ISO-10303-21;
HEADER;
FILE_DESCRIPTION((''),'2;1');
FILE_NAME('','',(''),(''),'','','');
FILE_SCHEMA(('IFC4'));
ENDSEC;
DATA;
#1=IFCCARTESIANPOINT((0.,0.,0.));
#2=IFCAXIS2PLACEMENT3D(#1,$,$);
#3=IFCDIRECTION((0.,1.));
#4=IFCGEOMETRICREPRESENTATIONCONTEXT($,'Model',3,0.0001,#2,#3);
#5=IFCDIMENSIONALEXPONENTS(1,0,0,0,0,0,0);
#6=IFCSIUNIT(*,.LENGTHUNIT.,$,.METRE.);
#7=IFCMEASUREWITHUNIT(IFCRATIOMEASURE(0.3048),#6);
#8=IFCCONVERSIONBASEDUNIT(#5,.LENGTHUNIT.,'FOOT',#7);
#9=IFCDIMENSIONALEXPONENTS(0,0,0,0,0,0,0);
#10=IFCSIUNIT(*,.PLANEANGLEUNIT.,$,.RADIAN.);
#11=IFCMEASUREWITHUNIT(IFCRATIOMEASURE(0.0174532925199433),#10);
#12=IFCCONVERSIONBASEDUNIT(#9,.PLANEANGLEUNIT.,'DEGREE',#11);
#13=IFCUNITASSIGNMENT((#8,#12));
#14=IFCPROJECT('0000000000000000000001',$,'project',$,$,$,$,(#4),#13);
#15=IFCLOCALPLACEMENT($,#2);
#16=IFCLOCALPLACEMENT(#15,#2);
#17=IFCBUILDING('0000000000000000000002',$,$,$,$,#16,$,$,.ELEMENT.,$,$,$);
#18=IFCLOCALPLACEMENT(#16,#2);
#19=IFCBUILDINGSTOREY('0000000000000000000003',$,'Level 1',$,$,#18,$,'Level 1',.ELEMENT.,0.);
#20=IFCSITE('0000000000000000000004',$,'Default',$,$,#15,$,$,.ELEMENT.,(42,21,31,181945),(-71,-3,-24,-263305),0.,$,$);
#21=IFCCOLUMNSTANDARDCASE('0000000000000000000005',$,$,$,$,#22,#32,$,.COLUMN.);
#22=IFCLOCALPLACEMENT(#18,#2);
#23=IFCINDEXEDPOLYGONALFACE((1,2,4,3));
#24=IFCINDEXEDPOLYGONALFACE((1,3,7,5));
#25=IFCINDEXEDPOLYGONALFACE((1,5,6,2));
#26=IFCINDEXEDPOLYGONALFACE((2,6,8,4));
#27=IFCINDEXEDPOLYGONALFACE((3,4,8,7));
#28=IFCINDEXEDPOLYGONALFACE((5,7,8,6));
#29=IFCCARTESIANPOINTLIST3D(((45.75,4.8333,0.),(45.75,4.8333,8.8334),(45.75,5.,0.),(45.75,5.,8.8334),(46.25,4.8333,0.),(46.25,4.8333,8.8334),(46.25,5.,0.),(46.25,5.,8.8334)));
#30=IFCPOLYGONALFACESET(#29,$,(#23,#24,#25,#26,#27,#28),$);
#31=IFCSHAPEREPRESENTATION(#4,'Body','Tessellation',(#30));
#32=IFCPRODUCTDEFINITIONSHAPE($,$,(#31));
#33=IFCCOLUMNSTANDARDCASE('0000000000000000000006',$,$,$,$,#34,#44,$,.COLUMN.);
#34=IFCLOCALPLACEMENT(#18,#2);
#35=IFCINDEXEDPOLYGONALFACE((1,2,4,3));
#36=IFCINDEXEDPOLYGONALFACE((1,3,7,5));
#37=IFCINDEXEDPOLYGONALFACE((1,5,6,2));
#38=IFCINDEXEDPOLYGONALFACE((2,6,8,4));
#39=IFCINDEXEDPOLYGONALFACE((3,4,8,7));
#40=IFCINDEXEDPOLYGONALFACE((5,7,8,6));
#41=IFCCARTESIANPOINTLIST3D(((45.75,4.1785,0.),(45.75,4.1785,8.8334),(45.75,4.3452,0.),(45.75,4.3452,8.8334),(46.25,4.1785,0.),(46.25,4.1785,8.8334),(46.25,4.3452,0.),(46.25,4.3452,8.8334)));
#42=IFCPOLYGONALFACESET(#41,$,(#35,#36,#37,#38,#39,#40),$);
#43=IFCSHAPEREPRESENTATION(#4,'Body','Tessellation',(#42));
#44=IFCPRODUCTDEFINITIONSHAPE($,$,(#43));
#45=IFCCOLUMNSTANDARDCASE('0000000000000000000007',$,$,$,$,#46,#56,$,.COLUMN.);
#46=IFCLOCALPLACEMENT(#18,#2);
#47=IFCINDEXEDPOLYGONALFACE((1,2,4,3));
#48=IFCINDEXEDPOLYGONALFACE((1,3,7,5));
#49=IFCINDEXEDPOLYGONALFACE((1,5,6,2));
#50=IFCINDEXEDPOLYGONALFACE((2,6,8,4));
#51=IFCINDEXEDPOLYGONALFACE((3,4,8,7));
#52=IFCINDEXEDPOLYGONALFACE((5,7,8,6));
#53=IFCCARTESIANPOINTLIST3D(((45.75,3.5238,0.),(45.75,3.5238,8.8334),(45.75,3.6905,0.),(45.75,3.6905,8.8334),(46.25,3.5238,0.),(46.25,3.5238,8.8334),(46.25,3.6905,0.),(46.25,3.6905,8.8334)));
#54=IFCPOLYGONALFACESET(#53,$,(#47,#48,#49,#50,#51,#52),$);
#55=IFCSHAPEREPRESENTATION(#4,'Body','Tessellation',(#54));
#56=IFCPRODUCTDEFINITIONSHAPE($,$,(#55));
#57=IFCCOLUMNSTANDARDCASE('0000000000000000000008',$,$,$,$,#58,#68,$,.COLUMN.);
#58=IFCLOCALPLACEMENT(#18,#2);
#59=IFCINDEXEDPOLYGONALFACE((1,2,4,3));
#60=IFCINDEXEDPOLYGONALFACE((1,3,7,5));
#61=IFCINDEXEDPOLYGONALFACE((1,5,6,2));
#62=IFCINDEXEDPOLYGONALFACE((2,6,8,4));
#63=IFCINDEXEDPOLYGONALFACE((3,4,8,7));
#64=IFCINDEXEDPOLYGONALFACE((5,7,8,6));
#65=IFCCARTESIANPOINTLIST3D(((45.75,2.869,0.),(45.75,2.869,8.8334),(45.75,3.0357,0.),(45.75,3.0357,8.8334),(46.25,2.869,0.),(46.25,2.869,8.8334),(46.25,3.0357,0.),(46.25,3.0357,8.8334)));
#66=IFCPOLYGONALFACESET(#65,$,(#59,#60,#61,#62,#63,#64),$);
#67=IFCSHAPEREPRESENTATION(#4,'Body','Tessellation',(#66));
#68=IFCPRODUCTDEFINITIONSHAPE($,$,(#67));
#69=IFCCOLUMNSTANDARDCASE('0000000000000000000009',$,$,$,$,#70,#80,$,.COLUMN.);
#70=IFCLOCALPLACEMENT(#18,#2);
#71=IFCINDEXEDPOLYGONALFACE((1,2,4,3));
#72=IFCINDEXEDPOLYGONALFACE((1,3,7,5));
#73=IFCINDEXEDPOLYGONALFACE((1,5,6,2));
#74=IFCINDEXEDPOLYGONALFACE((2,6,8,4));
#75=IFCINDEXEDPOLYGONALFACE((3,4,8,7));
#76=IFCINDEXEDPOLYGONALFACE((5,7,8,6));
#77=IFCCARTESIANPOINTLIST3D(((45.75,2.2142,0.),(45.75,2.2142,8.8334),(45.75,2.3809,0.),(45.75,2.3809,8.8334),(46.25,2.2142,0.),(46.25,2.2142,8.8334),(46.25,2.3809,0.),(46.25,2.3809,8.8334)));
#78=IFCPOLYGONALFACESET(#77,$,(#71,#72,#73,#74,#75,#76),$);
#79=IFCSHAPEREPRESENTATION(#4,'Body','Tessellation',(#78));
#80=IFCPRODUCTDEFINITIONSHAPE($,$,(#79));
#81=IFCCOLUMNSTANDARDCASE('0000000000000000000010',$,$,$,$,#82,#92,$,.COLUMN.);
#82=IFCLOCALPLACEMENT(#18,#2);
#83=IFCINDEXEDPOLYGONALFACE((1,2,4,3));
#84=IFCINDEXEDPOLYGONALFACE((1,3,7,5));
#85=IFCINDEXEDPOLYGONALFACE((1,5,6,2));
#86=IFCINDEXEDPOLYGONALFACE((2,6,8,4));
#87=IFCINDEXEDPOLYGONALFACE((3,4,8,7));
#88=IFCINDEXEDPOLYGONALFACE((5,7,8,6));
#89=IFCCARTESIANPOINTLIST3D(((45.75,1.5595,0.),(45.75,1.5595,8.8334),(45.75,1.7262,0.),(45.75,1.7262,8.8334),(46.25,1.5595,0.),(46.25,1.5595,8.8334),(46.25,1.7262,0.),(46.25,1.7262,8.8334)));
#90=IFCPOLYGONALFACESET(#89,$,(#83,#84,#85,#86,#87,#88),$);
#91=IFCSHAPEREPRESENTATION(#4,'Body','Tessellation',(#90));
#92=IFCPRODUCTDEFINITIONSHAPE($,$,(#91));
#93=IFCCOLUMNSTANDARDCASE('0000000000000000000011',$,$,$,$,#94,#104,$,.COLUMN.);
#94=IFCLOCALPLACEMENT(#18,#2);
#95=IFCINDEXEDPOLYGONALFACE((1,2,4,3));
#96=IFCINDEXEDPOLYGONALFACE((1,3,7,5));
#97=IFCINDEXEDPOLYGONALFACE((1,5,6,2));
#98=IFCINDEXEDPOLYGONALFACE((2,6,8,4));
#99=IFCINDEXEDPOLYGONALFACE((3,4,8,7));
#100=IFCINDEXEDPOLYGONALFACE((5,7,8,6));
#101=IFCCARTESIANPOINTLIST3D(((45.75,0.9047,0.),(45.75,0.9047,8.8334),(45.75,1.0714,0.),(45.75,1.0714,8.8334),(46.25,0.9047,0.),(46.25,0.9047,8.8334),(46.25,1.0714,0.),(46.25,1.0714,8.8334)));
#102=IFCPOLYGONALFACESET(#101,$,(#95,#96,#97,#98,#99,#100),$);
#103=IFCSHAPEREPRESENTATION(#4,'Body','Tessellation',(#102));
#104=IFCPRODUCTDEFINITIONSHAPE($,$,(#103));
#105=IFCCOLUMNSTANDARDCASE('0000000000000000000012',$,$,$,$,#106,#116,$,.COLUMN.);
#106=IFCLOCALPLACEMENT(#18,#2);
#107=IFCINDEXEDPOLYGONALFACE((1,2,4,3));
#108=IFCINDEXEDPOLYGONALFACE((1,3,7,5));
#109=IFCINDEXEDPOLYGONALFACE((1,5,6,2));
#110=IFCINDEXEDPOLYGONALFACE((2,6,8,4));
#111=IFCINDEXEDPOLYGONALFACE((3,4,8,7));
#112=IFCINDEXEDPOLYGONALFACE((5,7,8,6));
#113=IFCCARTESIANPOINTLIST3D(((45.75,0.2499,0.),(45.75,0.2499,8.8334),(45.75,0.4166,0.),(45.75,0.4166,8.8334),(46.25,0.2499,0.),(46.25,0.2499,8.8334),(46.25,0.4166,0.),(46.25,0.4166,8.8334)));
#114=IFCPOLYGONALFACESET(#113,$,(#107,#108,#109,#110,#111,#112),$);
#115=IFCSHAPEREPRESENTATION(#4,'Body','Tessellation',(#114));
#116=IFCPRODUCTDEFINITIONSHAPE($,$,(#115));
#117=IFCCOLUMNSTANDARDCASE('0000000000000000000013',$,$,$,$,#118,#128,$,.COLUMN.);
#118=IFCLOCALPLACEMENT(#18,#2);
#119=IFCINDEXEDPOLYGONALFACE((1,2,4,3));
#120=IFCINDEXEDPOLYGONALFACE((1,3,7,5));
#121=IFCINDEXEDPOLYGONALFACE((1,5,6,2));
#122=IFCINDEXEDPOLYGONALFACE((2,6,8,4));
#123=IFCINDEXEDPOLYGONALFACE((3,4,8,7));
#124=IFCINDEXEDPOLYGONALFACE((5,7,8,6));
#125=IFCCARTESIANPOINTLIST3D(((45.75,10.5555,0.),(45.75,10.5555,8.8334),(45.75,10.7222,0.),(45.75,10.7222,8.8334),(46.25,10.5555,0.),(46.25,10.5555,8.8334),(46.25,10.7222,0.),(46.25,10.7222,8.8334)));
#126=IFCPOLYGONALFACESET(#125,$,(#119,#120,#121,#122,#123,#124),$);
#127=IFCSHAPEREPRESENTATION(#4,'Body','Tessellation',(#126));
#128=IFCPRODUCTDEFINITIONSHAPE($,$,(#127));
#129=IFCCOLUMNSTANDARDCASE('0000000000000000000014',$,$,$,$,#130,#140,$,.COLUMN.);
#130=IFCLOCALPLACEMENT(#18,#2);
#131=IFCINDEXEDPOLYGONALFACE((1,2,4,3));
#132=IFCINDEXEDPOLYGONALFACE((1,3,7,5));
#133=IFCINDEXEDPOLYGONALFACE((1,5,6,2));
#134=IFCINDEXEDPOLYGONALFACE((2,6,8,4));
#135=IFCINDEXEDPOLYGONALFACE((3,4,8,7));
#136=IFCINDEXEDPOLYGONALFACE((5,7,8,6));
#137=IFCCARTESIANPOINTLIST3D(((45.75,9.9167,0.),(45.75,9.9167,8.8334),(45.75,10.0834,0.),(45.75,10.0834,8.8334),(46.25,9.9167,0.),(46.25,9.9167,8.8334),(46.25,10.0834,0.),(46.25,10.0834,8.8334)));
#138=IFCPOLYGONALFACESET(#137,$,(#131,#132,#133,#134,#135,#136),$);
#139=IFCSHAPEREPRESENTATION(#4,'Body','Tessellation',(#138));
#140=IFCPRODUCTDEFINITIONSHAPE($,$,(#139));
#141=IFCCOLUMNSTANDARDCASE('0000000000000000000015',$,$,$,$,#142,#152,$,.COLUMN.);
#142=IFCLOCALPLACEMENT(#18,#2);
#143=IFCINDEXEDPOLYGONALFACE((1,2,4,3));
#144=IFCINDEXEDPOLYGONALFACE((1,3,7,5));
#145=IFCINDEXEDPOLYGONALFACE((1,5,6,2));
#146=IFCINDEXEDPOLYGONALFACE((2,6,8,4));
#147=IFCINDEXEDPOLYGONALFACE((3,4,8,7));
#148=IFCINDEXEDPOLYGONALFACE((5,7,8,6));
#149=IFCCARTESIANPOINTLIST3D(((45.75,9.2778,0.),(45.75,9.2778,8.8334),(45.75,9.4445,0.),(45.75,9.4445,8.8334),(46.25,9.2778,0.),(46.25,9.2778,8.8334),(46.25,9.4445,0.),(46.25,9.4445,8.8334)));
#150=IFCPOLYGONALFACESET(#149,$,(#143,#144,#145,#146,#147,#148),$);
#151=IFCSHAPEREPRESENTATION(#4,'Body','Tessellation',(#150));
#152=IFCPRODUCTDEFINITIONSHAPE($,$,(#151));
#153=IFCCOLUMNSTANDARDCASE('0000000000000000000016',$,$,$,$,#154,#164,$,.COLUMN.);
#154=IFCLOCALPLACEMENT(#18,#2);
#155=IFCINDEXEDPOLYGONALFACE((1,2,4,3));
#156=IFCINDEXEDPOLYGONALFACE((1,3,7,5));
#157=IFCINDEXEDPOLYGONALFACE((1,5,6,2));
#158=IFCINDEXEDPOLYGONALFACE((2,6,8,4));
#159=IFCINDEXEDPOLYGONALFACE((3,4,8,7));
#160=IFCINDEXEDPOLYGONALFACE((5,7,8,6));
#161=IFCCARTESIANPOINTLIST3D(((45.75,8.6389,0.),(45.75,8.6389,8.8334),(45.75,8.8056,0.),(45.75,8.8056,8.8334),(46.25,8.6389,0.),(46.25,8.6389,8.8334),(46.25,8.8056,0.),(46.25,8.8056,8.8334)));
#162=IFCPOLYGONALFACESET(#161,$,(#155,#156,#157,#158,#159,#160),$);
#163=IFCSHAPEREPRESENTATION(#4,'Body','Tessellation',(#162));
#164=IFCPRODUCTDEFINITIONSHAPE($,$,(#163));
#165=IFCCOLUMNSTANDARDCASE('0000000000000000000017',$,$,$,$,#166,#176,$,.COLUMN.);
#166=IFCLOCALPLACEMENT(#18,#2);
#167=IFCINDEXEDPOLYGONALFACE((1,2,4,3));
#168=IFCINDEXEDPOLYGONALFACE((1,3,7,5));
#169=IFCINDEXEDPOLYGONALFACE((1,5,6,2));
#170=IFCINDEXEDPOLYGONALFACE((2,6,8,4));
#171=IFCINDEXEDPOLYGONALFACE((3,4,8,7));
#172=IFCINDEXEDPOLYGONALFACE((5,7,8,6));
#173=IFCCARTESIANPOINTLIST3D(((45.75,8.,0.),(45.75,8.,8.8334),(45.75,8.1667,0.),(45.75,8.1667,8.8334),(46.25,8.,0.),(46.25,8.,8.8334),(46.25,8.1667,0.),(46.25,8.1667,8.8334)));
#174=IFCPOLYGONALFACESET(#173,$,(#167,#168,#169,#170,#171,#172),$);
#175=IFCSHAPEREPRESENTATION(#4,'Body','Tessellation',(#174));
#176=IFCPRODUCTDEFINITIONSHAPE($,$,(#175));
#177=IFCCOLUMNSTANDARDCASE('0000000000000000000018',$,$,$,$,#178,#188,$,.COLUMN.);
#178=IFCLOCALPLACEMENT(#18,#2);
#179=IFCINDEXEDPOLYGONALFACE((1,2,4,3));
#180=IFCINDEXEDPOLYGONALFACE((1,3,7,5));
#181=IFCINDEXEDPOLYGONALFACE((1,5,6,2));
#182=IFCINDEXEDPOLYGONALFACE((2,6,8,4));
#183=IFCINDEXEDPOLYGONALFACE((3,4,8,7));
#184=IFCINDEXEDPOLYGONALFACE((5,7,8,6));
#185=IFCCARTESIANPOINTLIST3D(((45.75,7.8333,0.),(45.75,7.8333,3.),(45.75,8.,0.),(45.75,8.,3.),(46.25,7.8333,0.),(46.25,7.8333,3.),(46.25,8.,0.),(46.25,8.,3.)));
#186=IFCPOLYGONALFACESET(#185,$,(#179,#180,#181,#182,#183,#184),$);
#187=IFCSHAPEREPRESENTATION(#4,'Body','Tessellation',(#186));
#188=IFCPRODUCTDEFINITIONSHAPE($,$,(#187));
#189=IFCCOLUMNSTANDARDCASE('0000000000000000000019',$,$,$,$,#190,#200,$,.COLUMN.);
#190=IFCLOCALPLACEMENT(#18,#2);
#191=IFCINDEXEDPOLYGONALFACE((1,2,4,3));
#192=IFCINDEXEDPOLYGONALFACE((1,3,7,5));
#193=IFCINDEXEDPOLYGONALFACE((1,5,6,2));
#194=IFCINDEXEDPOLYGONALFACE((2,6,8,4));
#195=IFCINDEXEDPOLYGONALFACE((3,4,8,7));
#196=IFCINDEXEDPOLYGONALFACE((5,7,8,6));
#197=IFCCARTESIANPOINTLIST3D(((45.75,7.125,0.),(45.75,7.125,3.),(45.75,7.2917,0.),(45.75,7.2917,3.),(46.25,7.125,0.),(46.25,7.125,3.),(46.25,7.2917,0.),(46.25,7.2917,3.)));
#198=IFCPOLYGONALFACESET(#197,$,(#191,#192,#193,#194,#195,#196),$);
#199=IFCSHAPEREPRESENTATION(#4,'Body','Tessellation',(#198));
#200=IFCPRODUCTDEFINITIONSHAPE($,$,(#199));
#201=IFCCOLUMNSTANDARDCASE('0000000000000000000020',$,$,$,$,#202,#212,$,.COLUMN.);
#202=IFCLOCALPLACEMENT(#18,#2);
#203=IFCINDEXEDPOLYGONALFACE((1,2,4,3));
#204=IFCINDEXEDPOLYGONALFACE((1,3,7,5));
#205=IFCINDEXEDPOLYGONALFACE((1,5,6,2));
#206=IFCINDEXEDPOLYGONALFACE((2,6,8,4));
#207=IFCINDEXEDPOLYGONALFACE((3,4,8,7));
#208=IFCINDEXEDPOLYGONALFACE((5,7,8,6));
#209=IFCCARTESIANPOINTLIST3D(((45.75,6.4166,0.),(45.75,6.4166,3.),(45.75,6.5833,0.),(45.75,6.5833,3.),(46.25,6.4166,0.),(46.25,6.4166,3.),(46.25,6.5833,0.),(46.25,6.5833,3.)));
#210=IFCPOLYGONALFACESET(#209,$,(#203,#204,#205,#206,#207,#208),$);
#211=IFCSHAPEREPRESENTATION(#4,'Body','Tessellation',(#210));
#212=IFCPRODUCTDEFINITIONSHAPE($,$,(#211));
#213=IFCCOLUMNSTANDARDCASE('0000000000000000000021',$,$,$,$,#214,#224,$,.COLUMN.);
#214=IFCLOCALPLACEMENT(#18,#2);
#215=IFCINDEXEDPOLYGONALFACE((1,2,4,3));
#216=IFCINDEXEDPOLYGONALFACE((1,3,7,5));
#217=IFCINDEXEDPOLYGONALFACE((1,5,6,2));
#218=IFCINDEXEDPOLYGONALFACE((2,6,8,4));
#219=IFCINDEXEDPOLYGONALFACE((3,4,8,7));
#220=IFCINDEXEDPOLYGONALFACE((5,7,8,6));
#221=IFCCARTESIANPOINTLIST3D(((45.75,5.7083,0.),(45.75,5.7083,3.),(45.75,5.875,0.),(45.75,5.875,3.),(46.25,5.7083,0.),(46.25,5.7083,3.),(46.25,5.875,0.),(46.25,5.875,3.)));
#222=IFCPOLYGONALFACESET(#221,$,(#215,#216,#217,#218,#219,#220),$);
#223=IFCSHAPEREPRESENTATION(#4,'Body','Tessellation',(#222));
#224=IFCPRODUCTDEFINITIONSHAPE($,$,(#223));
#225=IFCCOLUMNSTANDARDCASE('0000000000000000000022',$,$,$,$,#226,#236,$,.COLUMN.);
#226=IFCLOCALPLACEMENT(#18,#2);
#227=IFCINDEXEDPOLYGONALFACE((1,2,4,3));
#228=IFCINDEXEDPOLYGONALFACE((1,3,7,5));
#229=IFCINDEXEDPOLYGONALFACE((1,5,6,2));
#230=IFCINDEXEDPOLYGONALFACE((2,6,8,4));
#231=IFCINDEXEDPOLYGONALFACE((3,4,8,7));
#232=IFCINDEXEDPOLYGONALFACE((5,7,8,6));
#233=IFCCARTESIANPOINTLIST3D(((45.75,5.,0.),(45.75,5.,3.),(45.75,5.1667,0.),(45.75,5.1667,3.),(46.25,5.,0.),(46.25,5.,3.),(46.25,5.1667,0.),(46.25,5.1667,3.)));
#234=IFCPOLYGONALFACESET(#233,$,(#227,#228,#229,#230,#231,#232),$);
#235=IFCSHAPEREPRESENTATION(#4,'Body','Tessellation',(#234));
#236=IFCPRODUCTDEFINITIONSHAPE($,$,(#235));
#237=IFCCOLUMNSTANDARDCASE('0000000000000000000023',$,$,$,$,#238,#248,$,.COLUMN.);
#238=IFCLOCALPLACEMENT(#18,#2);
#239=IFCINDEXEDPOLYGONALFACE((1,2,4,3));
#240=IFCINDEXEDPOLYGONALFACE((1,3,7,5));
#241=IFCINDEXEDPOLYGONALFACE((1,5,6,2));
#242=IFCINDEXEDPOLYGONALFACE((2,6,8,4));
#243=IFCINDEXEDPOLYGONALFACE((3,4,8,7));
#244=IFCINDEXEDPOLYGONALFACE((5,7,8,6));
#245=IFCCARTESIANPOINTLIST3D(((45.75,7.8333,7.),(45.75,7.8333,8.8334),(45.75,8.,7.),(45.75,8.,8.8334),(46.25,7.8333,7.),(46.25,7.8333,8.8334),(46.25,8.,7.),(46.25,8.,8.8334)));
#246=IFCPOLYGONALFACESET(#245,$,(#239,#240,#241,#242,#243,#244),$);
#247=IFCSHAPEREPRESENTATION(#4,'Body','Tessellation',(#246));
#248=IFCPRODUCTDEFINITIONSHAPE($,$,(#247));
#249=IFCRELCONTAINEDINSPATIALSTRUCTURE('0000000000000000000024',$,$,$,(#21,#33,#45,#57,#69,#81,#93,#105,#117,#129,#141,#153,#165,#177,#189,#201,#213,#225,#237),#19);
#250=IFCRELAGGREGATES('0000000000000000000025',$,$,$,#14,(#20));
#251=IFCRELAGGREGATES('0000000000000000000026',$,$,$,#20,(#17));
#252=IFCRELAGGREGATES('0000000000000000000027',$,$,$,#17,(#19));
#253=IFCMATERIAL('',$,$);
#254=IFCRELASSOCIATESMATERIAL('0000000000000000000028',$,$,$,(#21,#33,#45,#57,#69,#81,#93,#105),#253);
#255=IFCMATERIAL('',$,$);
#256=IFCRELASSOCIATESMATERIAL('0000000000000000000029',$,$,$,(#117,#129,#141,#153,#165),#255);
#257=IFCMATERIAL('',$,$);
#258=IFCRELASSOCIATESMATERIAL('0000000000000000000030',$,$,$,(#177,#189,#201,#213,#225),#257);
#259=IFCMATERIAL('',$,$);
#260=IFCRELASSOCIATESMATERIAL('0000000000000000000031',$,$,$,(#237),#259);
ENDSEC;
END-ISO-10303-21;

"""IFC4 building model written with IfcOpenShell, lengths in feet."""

from ifc_helpers import new_model, entity, si_unit, converted_unit, direction, frame, origin, place, context, project, spatial, rectangle, extrude, material, element, save


model = new_model("IFC4")

# Units and contexts
model_context = context("Model", 3, precision=0.0001, world=origin(), true_north=direction((0.0, 1.0)))
ifc_project = project(units=[converted_unit("LENGTHUNIT", "FOOT", entity("IfcRatioMeasure", 0.3048), si_unit("LENGTHUNIT", "METRE"), dimensions=[1, 0, 0, 0, 0, 0, 0]), converted_unit("PLANEANGLEUNIT", "DEGREE", entity("IfcRatioMeasure", 0.0174532925199433), si_unit("PLANEANGLEUNIT", "RADIAN"), dimensions=[0, 0, 0, 0, 0, 0, 0])], contexts=[model_context])

# Site, building, storey
site_placement = place(None, origin())
site = spatial("IfcSite", under=ifc_project, at=site_placement, Name="Default", CompositionType="ELEMENT", RefLatitude=(42, 21, 31, 181945), RefLongitude=(-71, -3, -24, -263305), RefElevation=0.0)
building_placement = place(site_placement, origin())
building = spatial("IfcBuilding", under=site, at=building_placement, CompositionType="ELEMENT")
storey_placement = place(building_placement, origin())
storey = spatial("IfcBuildingStorey", under=building, at=storey_placement, Name="Level 1", LongName="Level 1", CompositionType="ELEMENT", Elevation=0.0)

# Columns
ifc_material_1 = material(Name="")
placement_1 = place(storey_placement, frame((46.0, 46.25, 0.0), z_axis=(0.0, 0.0, 1.0), x_axis=(0.0, -1.0, 0.0)))
for number, where, z_axis, x_axis in (
    (1, (41.3334, 0.0, 0.0), (0.0, 0.0, 1.0), (1.0, 0.0, 0.0)),
    (2, (41.9882, 0.0, 0.0), (0.0, 0.0, 1.0), (1.0, 0.0, 0.0)),
    (3, (42.6429, 0.0, 0.0), (0.0, 0.0, 1.0), (1.0, 0.0, 0.0)),
    (4, (43.2977, 0.0, 0.0), (0.0, 0.0, 1.0), (1.0, 0.0, 0.0)),
    (5, (43.9525, 0.0, 0.0), (0.0, 0.0, 1.0), (1.0, 0.0, 0.0)),
    (6, (44.6072, 0.0, 0.0), (0.0, 0.0, 1.0), (1.0, 0.0, 0.0)),
    (7, (45.262, 0.0, 0.0), (0.0, 0.0, 1.0), (1.0, 0.0, 0.0)),
    (8, (45.9168, 0.0, 0.0), (0.0, 0.0, 1.0), (1.0, 0.0, 0.0)),
):
    element("IfcColumnStandardCase", number, at=place(placement_1, frame(where, z_axis=z_axis, x_axis=x_axis)), inside=storey, material=ifc_material_1, PredefinedType="COLUMN", context=model_context, shape_type="SweptSolid", body=[
        extrude(rectangle(XDim=0.1667, YDim=0.5), origin(), (0.0, 0.0, 1.0), 8.8334),
    ])
ifc_material_2 = material(Name="")
for number, where, z_axis, x_axis in (
    (9, (35.6112, 0.0, 0.0), (0.0, 0.0, 1.0), (1.0, 0.0, 0.0)),
    (10, (36.25, 0.0, 0.0), (0.0, 0.0, 1.0), (1.0, 0.0, 0.0)),
    (11, (36.8889, 0.0, 0.0), (0.0, 0.0, 1.0), (1.0, 0.0, 0.0)),
    (12, (37.5278, 0.0, 0.0), (0.0, 0.0, 1.0), (1.0, 0.0, 0.0)),
    (13, (38.1667, 0.0, 0.0), (0.0, 0.0, 1.0), (1.0, 0.0, 0.0)),
):
    element("IfcColumnStandardCase", number, at=place(placement_1, frame(where, z_axis=z_axis, x_axis=x_axis)), inside=storey, material=ifc_material_2, PredefinedType="COLUMN", context=model_context, shape_type="SweptSolid", body=[
        extrude(rectangle(XDim=0.1667, YDim=0.5), origin(), (0.0, 0.0, 1.0), 8.8334),
    ])
ifc_material_3 = material(Name="")
for number, where, z_axis, x_axis in (
    (14, (38.3334, 0.0, 0.0), (0.0, 0.0, 1.0), (1.0, 0.0, 0.0)),
    (15, (39.0417, 0.0, 0.0), (0.0, 0.0, 1.0), (1.0, 0.0, 0.0)),
    (16, (39.7501, 0.0, 0.0), (0.0, 0.0, 1.0), (1.0, 0.0, 0.0)),
    (17, (40.4584, 0.0, 0.0), (0.0, 0.0, 1.0), (1.0, 0.0, 0.0)),
    (18, (41.1667, 0.0, 0.0), (0.0, 0.0, 1.0), (1.0, 0.0, 0.0)),
):
    element("IfcColumnStandardCase", number, at=place(placement_1, frame(where, z_axis=z_axis, x_axis=x_axis)), inside=storey, material=ifc_material_3, PredefinedType="COLUMN", context=model_context, shape_type="SweptSolid", body=[
        extrude(rectangle(XDim=0.1667, YDim=0.5), origin(), (0.0, 0.0, 1.0), 3.0),
    ])
ifc_material_4 = material(Name="")
for number, where, z_axis, x_axis in (
    (19, (38.3334, 0.0, 7.0), (0.0, 0.0, 1.0), (1.0, 0.0, 0.0)),
):
    element("IfcColumnStandardCase", number, at=place(placement_1, frame(where, z_axis=z_axis, x_axis=x_axis)), inside=storey, material=ifc_material_4, PredefinedType="COLUMN", context=model_context, shape_type="SweptSolid", body=[
        extrude(rectangle(XDim=0.1667, YDim=0.5), origin(), (0.0, 0.0, 1.0), 1.8334),
    ])

save(model, "model.ifc")
